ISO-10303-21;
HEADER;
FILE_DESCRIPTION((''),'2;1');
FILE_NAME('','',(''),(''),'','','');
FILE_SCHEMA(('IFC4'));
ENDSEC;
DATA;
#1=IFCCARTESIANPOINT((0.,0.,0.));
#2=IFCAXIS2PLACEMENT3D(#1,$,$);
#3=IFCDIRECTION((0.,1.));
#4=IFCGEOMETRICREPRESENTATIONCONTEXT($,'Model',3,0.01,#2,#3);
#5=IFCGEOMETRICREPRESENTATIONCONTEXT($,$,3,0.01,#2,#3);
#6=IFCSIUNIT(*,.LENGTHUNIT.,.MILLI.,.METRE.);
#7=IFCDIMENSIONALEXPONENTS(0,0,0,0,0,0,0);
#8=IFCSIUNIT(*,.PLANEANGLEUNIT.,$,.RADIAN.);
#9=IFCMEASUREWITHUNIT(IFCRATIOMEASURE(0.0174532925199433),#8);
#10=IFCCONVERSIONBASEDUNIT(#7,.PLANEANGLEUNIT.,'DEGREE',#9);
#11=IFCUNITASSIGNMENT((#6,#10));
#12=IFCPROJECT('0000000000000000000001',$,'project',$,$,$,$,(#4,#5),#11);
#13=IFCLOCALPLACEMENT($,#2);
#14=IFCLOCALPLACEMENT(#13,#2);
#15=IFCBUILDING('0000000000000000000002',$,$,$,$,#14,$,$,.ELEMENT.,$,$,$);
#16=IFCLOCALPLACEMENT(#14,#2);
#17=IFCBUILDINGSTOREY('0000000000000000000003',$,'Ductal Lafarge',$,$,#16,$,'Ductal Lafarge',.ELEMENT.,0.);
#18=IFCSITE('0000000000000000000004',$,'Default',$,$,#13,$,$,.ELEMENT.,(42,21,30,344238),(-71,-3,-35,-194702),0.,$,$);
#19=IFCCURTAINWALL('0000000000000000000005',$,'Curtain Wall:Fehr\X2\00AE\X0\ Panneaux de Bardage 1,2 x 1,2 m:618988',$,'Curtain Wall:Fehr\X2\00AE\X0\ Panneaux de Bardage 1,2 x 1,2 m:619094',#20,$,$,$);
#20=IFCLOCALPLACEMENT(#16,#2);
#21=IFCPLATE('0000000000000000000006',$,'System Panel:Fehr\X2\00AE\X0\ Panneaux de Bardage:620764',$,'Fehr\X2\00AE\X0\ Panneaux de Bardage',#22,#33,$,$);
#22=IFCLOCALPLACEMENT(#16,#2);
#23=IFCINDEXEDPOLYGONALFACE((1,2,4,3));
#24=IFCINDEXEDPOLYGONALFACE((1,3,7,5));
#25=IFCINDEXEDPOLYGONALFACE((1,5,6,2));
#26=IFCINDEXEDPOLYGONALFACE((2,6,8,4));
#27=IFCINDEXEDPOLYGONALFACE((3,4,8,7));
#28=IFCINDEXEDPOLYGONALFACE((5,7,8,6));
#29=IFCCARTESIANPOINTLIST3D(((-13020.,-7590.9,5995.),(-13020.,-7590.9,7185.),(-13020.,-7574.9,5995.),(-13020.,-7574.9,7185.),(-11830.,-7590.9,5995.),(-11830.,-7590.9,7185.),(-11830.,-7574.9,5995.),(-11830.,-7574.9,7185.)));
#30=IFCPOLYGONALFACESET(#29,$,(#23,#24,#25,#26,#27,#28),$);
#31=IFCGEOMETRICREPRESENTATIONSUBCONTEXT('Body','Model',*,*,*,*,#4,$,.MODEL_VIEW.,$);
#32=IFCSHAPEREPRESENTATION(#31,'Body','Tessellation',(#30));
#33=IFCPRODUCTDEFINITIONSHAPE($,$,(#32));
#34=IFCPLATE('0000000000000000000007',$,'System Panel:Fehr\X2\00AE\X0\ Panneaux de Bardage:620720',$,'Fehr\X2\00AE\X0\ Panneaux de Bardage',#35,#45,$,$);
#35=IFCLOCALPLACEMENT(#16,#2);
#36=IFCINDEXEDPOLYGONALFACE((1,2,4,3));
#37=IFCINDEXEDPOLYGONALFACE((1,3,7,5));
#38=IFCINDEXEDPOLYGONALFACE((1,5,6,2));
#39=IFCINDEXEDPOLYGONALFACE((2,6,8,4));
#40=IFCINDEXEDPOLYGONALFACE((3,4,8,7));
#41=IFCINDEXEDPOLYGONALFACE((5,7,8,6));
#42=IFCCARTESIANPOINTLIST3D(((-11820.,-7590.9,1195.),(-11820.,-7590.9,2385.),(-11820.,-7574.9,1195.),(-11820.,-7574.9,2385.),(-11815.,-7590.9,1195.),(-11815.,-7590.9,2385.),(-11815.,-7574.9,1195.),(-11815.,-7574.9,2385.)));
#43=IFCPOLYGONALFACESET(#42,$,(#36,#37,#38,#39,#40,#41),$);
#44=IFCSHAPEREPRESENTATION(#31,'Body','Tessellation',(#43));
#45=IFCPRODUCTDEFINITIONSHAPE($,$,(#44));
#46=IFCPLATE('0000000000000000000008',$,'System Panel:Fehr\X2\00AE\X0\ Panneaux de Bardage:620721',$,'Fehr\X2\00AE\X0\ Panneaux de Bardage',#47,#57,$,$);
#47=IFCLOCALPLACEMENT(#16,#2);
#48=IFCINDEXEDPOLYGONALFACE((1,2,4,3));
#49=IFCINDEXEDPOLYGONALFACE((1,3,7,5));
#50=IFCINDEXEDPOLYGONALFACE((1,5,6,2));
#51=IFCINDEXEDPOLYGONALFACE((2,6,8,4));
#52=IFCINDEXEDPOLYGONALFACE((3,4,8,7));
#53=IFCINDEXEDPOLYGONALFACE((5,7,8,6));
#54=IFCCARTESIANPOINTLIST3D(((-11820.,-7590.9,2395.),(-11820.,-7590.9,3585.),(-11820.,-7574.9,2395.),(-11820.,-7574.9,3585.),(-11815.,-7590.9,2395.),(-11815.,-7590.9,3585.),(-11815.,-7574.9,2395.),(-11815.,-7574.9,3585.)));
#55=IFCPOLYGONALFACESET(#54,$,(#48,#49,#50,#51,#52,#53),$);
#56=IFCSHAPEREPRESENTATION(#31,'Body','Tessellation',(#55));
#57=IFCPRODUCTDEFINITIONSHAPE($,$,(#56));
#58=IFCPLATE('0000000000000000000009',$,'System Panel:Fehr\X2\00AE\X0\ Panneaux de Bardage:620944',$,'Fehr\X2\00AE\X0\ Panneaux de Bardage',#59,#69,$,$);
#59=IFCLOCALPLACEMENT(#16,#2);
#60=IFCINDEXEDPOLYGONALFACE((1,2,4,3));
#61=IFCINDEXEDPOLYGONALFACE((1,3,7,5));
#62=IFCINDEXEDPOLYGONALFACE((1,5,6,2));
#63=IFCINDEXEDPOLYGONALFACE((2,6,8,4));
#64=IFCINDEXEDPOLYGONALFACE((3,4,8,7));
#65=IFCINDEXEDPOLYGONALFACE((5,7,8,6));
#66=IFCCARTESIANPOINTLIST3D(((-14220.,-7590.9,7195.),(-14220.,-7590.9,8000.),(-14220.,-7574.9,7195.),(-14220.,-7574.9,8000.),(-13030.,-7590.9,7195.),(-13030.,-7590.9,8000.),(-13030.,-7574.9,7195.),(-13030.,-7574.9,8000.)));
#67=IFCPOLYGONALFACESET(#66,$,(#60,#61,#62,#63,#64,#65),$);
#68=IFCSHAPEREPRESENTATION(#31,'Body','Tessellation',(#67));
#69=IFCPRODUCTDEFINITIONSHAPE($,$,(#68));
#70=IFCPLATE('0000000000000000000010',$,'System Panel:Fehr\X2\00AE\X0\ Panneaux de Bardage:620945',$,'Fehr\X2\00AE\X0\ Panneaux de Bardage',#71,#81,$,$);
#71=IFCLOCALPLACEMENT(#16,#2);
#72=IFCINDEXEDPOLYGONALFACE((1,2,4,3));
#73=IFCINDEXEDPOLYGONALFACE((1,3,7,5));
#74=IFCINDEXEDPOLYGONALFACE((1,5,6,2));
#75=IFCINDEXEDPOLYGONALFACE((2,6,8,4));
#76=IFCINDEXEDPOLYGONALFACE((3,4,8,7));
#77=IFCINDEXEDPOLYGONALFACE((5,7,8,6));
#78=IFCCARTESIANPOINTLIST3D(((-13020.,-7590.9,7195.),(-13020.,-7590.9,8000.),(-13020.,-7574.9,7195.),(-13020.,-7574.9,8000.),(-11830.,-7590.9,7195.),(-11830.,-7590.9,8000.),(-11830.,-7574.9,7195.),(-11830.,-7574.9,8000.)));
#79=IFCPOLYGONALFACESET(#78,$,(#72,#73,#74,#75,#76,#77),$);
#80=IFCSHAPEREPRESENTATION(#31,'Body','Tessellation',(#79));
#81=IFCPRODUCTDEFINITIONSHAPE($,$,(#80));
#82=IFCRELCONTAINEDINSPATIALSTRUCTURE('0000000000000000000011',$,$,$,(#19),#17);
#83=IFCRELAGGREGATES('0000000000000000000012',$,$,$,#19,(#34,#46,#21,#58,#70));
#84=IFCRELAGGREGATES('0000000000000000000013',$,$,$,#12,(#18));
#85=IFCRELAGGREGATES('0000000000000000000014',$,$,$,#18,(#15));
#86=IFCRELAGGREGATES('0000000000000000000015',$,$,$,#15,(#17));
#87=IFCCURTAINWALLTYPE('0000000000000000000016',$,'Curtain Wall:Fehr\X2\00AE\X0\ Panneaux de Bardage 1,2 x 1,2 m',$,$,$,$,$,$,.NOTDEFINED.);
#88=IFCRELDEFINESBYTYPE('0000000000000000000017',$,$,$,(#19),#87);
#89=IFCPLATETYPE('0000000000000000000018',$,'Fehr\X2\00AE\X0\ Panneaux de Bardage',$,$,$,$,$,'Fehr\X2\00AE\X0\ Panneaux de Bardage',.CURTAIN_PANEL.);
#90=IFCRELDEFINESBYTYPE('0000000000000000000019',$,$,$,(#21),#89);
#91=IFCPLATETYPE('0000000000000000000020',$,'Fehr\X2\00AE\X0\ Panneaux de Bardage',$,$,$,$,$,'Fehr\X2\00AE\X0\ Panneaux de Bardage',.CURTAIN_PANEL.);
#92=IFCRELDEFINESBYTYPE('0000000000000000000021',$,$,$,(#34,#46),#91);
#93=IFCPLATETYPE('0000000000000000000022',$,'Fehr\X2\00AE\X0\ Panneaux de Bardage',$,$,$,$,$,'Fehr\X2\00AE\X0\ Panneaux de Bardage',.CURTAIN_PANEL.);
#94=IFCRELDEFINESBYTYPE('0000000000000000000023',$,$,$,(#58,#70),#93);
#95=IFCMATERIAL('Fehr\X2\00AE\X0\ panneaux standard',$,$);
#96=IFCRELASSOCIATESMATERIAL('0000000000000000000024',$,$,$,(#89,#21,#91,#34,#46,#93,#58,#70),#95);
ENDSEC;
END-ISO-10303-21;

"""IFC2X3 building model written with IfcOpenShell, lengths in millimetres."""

from ifc_helpers import new_model, entity, si_unit, converted_unit, direction, frame, origin, origin_2d_with_axis, place, context, subcontext, project, spatial, rectangle, extrude, source, transform, mapped, material, type_object, type_shapes, element, aggregate, save


model = new_model("IFC2X3")

# Units and contexts
model_context = context("Model", 3, precision=0.01, world=origin(), true_north=direction((0.0, 1.0)))
context_of_model = context(None, 3, precision=0.01, world=origin(), true_north=direction((0.0, 1.0)))
body_context = subcontext(model_context, "Body", "Model", "MODEL_VIEW")
ifc_project = project(units=[si_unit("LENGTHUNIT", "METRE", prefix="MILLI"), converted_unit("PLANEANGLEUNIT", "DEGREE", entity("IfcRatioMeasure", 0.0174532925199433), si_unit("PLANEANGLEUNIT", "RADIAN"), dimensions=[0, 0, 0, 0, 0, 0, 0])], contexts=[model_context, context_of_model])

# Site, building, storey
site_placement = place(None, origin())
site = spatial("IfcSite", under=ifc_project, at=site_placement, Name="Default", CompositionType="ELEMENT", RefLatitude=(42, 21, 30, 344238), RefLongitude=(-71, -3, -35, -194702), RefElevation=0.0)
building_placement = place(site_placement, origin())
building = spatial("IfcBuilding", under=site, at=building_placement, CompositionType="ELEMENT")
storey_placement = place(building_placement, origin())
storey = spatial("IfcBuildingStorey", under=building, at=storey_placement, Name="Ductal Lafarge", LongName="Ductal Lafarge", CompositionType="ELEMENT", Elevation=0.0)

# Curtain wall, plates
curtain_wall_type_1 = type_object("IfcCurtainWallType", Name="Curtain Wall:Fehr® Panneaux de Bardage 1,2 x 1,2 m", PredefinedType="NOTDEFINED")
curtain_wall_1_placement = place(storey_placement, origin())
curtain_wall_1 = element("IfcCurtainWall", 1, at=curtain_wall_1_placement, inside=storey, type_object=curtain_wall_type_1, Name="Curtain Wall:Fehr® Panneaux de Bardage 1,2 x 1,2 m:618988", ObjectType="Curtain Wall:Fehr® Panneaux de Bardage 1,2 x 1,2 m:619094")
ifc_material_1 = material(Name="Fehr® panneaux standard")
plate_type_1 = type_object("IfcPlateType", Name="Fehr® Panneaux de Bardage", ElementType="Fehr® Panneaux de Bardage", PredefinedType="CURTAIN_PANEL", material=ifc_material_1)
shared_shape_1 = source(origin(), body_context, "Body", "SweptSolid", [
    extrude(rectangle(XDim=16.0, YDim=1190.0, at=origin_2d_with_axis()), frame((0.0, 0.0, 0.0), z_axis=(0.0, 0.0, 1.0), x_axis=(0.0, 1.0, 0.0)), (0.0, 0.0, 1.0), 1190.0),
])
type_shapes(plate_type_1, [shared_shape_1])
plate_1_placement = place(curtain_wall_1_placement, frame((-12425.0, -7582.9, 5995.0)))
plate_1 = element("IfcPlate", 2, at=plate_1_placement, type_object=plate_type_1, material=ifc_material_1, Name="System Panel:Fehr® Panneaux de Bardage:620764", ObjectType="Fehr® Panneaux de Bardage", context=body_context, shape_type="MappedRepresentation", body=[
    mapped(shared_shape_1, transform((0.0, 0.0, 0.0), scale=1.0)),
])
plate_type_2 = type_object("IfcPlateType", Name="Fehr® Panneaux de Bardage", ElementType="Fehr® Panneaux de Bardage", PredefinedType="CURTAIN_PANEL", material=ifc_material_1)
shared_shape_2 = source(origin(), body_context, "Body", "SweptSolid", [
    extrude(rectangle(XDim=16.0, YDim=5.0, at=origin_2d_with_axis()), frame((0.0, 0.0, 0.0), z_axis=(0.0, 0.0, 1.0), x_axis=(0.0, 1.0, 0.0)), (0.0, 0.0, 1.0), 1190.0),
])
type_shapes(plate_type_2, [shared_shape_2])
plate_2_placement = place(curtain_wall_1_placement, frame((-11817.5, -7582.9, 1195.0)))
plate_2 = element("IfcPlate", 3, at=plate_2_placement, type_object=plate_type_2, material=ifc_material_1, Name="System Panel:Fehr® Panneaux de Bardage:620720", ObjectType="Fehr® Panneaux de Bardage", context=body_context, shape_type="MappedRepresentation", body=[
    mapped(shared_shape_2, transform((0.0, 0.0, 0.0), scale=1.0)),
])
plate_3_placement = place(curtain_wall_1_placement, frame((-11817.5, -7582.9, 2395.0)))
plate_3 = element("IfcPlate", 4, at=plate_3_placement, type_object=plate_type_2, material=ifc_material_1, Name="System Panel:Fehr® Panneaux de Bardage:620721", ObjectType="Fehr® Panneaux de Bardage", context=body_context, shape_type="MappedRepresentation", body=[
    mapped(shared_shape_2, transform((0.0, 0.0, 0.0), scale=1.0)),
])
plate_type_3 = type_object("IfcPlateType", Name="Fehr® Panneaux de Bardage", ElementType="Fehr® Panneaux de Bardage", PredefinedType="CURTAIN_PANEL", material=ifc_material_1)
shared_shape_3 = source(origin(), body_context, "Body", "SweptSolid", [
    extrude(rectangle(XDim=16.0, YDim=1190.0, at=origin_2d_with_axis()), frame((0.0, 0.0, 0.0), z_axis=(0.0, 0.0, 1.0), x_axis=(0.0, 1.0, 0.0)), (0.0, 0.0, 1.0), 805.0),
])
type_shapes(plate_type_3, [shared_shape_3])
plate_4_placement = place(curtain_wall_1_placement, frame((-13625.0, -7582.9, 7195.0)))
plate_4 = element("IfcPlate", 5, at=plate_4_placement, type_object=plate_type_3, material=ifc_material_1, Name="System Panel:Fehr® Panneaux de Bardage:620944", ObjectType="Fehr® Panneaux de Bardage", context=body_context, shape_type="MappedRepresentation", body=[
    mapped(shared_shape_3, transform((0.0, 0.0, 0.0), scale=1.0)),
])
plate_5_placement = place(curtain_wall_1_placement, frame((-12425.0, -7582.9, 7195.0)))
plate_5 = element("IfcPlate", 6, at=plate_5_placement, type_object=plate_type_3, material=ifc_material_1, Name="System Panel:Fehr® Panneaux de Bardage:620945", ObjectType="Fehr® Panneaux de Bardage", context=body_context, shape_type="MappedRepresentation", body=[
    mapped(shared_shape_3, transform((0.0, 0.0, 0.0), scale=1.0)),
])
aggregate(curtain_wall_1, [plate_2, plate_3, plate_1, plate_4, plate_5])

save(model, "model.ifc")
